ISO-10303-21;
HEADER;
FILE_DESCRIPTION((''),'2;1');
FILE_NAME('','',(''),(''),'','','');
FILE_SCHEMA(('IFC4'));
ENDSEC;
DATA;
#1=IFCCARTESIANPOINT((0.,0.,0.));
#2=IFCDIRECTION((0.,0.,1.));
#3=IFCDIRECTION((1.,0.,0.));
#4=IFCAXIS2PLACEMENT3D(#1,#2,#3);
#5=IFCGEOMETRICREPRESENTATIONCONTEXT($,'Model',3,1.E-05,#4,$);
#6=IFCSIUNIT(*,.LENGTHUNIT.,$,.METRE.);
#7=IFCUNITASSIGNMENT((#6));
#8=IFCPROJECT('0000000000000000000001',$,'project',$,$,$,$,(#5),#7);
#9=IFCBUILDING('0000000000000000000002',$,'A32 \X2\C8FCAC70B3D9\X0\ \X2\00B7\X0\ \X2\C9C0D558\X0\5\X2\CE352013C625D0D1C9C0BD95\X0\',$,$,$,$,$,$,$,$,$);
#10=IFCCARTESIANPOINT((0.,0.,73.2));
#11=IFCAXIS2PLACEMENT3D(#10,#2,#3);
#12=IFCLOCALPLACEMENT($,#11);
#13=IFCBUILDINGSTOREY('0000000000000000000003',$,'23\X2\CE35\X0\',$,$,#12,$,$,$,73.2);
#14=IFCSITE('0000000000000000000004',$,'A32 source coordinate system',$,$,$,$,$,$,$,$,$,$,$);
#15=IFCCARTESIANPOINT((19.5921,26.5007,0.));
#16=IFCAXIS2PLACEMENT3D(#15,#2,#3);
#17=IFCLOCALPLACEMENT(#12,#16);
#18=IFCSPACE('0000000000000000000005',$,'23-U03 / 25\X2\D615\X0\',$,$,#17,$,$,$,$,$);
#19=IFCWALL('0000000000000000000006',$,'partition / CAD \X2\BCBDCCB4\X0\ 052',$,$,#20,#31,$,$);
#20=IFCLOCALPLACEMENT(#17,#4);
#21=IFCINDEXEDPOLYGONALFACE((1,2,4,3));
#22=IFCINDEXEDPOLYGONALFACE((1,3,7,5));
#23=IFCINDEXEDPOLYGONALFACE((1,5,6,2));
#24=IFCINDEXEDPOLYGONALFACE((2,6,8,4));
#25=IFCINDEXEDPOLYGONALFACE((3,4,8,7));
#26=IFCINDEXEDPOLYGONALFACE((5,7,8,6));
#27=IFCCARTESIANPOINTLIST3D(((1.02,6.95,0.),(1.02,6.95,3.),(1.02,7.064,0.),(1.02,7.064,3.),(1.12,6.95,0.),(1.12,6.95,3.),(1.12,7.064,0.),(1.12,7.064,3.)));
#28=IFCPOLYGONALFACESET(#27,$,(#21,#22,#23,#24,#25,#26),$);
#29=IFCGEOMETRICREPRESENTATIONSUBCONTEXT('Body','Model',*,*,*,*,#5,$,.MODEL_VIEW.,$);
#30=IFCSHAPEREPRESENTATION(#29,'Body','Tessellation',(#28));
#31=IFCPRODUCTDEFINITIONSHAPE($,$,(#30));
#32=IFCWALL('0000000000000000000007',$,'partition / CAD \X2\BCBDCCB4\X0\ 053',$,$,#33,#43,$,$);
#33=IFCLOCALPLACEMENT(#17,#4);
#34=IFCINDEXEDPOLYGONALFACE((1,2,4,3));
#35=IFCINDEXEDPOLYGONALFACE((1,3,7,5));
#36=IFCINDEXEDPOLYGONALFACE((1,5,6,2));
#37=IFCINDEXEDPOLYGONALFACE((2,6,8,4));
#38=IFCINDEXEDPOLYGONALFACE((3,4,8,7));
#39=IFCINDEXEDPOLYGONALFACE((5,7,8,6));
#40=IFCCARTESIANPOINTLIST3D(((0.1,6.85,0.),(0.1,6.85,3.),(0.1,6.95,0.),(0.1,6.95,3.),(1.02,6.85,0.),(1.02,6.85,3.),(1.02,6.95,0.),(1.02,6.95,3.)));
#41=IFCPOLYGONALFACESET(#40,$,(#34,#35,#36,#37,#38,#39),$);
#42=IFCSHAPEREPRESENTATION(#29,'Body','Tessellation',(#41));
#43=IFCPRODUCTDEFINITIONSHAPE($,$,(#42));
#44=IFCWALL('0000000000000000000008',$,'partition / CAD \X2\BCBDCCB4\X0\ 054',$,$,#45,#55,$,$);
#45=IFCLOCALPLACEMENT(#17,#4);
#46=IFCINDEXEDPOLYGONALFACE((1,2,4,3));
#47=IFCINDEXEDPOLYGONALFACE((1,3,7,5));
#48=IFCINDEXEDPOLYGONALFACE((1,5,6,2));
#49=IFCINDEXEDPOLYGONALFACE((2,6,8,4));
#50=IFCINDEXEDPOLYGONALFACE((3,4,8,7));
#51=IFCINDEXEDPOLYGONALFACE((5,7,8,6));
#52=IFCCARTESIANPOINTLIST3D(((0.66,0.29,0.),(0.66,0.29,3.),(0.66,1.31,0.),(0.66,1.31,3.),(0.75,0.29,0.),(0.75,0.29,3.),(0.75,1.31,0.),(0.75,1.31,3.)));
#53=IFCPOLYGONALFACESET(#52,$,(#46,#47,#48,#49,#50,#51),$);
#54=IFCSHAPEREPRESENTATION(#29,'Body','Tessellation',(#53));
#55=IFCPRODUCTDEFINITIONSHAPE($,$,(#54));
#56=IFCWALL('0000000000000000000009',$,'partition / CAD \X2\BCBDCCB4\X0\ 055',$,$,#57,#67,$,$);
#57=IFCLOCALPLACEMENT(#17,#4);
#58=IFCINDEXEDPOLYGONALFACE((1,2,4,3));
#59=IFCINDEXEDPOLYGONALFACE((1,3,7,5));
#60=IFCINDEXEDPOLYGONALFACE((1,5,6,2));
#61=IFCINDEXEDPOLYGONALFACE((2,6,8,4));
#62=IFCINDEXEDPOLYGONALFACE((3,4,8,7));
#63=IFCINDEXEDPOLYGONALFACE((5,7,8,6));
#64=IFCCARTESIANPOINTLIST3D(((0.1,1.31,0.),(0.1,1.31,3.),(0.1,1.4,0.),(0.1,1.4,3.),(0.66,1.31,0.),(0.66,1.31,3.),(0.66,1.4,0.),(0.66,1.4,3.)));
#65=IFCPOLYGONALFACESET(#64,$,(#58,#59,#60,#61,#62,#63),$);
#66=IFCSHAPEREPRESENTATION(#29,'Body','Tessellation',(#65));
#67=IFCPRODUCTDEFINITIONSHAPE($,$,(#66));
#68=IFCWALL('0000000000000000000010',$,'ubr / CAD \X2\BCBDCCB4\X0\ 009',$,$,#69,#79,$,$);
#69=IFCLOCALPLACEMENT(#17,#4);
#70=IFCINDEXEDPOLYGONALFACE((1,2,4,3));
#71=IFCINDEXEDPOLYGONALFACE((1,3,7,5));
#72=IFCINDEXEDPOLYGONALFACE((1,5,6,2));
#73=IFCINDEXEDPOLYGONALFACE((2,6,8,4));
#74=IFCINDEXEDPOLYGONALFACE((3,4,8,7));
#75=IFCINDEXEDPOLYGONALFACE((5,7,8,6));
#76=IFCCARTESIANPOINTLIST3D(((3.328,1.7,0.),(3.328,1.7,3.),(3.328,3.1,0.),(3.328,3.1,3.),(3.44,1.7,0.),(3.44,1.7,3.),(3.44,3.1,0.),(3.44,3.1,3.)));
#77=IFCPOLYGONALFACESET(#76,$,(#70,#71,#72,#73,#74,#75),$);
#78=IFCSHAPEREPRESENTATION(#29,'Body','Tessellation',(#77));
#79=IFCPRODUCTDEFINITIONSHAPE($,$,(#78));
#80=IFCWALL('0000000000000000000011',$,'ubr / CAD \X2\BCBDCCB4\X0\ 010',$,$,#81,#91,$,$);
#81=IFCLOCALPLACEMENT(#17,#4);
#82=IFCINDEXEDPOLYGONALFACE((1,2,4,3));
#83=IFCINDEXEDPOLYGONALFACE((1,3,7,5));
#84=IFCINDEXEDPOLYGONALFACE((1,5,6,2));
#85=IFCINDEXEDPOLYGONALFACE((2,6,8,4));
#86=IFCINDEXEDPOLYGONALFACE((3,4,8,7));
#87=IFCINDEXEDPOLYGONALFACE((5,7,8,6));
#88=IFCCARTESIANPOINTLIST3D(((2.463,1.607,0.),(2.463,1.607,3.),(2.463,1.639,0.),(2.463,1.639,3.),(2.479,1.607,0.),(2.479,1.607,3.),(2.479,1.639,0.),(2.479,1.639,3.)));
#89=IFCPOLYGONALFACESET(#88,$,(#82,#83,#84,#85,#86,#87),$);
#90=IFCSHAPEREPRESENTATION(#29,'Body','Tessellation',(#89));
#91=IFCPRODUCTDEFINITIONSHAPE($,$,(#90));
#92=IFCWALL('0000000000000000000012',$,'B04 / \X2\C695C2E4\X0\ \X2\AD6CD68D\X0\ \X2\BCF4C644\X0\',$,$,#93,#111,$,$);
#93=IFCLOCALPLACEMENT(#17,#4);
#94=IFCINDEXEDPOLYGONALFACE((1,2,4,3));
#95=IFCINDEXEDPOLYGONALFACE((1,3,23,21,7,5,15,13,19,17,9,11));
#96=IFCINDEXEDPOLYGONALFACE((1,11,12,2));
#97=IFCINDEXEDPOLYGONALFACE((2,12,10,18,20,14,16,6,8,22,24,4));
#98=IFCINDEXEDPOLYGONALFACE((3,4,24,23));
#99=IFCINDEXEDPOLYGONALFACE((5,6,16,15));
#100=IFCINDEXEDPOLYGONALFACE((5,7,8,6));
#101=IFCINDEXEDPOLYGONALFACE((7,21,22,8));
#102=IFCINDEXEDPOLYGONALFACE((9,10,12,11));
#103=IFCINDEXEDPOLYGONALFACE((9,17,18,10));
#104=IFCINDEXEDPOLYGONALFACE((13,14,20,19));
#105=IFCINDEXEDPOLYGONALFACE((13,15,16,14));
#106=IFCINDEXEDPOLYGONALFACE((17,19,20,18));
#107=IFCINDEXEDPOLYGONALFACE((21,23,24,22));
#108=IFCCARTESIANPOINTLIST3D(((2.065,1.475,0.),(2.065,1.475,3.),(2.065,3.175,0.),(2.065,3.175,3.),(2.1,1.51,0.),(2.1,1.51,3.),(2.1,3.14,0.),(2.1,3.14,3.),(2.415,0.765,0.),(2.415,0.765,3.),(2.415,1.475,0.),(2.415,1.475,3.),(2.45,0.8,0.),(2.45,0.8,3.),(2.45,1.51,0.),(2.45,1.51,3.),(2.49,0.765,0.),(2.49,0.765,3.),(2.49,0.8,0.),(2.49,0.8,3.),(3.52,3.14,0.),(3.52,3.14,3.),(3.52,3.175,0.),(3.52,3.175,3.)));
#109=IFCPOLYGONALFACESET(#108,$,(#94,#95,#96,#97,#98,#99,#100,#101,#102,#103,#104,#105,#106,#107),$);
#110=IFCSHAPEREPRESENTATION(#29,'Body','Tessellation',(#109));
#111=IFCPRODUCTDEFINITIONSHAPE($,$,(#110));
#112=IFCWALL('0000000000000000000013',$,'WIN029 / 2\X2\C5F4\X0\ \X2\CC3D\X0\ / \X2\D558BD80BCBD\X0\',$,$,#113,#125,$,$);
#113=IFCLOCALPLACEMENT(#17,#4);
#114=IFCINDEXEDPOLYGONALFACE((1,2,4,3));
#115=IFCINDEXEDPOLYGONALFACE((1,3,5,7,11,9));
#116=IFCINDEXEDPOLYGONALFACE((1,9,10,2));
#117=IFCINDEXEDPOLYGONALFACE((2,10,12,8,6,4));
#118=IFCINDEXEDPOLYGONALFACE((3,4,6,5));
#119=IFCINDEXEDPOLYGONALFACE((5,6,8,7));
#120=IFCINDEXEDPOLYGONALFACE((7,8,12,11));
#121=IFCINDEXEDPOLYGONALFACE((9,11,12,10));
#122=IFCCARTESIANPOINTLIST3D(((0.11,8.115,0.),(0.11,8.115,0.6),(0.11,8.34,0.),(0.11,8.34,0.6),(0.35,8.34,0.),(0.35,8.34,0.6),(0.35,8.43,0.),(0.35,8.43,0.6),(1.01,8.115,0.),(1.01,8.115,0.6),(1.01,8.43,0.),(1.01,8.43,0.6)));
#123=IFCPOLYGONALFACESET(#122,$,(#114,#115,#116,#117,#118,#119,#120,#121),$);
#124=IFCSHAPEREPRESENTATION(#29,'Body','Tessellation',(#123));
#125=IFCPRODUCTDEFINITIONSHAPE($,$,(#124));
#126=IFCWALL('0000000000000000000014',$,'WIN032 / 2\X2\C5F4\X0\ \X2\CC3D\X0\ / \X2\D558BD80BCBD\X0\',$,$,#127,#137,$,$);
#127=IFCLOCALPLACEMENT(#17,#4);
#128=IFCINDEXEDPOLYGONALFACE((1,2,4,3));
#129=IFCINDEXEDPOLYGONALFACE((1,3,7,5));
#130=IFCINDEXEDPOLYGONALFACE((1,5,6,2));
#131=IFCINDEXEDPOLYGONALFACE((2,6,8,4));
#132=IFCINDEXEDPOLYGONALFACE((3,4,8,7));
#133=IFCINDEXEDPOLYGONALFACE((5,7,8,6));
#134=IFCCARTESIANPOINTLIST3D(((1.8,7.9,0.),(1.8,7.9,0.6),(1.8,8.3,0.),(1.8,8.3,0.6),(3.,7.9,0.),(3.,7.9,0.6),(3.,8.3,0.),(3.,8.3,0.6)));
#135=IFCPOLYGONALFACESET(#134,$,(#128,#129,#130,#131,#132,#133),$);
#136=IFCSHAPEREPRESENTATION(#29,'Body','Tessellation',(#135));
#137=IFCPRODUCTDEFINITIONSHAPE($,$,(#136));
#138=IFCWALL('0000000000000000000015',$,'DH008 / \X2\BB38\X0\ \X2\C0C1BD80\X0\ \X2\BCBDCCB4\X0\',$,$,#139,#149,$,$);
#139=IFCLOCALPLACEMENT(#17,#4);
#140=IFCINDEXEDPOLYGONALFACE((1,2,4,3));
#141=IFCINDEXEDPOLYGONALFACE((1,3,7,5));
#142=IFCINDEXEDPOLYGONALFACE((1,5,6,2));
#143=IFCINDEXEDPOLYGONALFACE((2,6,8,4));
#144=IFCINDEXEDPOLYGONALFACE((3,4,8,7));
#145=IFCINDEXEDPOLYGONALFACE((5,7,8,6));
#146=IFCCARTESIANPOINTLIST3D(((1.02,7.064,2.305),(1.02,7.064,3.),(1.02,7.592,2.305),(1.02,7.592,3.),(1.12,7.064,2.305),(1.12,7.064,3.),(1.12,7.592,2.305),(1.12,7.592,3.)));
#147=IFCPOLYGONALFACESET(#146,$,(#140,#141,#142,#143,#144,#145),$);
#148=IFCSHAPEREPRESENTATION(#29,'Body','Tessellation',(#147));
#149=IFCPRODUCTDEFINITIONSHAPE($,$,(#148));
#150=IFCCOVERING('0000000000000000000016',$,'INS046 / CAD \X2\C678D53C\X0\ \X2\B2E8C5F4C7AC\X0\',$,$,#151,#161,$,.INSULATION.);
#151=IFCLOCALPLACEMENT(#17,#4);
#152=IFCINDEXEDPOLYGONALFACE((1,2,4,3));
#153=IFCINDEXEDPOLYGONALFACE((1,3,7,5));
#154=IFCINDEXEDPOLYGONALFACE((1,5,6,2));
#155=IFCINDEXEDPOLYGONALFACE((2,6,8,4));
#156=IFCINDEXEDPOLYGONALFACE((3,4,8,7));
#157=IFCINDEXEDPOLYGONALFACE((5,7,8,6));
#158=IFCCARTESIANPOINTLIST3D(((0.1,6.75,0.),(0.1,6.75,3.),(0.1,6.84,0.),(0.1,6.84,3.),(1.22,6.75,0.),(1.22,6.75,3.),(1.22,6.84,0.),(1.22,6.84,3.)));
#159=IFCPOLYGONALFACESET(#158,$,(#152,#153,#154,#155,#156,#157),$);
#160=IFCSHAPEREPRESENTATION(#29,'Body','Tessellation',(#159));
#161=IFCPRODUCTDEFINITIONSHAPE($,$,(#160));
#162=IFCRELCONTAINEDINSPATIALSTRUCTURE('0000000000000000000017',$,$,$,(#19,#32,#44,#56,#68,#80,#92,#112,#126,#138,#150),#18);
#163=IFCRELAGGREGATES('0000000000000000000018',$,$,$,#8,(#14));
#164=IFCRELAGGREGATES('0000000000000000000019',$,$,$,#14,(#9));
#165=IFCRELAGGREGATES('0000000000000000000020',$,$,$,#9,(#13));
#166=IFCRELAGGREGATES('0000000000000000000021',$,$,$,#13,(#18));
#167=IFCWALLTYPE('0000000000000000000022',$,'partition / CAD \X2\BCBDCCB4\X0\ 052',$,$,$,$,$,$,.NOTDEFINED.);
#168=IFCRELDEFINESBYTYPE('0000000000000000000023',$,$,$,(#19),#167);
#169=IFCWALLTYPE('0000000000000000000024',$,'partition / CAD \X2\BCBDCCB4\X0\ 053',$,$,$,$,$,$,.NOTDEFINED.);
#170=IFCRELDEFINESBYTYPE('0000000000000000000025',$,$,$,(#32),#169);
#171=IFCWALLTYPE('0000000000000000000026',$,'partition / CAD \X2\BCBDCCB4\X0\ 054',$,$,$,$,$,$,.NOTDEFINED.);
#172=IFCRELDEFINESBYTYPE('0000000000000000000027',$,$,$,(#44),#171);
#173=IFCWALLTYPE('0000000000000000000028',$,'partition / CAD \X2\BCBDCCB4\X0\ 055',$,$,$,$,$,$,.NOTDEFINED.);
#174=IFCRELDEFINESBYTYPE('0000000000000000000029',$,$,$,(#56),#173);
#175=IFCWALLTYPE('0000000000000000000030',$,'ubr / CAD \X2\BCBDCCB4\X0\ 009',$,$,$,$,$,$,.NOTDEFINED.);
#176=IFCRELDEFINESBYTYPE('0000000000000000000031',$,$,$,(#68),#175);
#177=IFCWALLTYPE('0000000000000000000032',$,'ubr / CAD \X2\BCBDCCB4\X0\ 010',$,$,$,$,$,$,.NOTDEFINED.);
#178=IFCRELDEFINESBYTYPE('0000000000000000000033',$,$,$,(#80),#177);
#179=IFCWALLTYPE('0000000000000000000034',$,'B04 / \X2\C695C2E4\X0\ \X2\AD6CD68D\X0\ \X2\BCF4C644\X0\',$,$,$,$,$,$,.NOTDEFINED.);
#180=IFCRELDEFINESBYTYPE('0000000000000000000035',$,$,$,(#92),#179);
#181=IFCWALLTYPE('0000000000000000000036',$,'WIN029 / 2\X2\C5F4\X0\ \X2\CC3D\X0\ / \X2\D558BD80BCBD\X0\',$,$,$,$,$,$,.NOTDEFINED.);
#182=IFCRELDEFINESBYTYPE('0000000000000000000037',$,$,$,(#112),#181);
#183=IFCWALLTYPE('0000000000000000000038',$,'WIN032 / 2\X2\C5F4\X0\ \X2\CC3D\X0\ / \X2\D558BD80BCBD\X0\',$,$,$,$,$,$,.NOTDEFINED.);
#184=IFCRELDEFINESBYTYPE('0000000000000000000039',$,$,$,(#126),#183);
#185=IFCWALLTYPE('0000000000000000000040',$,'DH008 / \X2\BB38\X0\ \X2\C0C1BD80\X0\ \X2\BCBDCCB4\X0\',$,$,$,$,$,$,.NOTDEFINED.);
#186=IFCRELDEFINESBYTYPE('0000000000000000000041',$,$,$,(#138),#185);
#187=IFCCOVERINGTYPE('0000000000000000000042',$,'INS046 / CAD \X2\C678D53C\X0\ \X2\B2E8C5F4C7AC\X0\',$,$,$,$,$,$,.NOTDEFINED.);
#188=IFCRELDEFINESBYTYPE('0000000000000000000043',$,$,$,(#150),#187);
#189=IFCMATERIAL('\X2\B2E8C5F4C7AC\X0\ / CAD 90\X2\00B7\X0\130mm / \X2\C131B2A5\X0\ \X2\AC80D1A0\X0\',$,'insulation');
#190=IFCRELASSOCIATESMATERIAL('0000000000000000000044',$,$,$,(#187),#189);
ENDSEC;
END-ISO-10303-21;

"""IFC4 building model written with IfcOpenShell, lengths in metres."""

from ifc_helpers import new_model, si_unit, frame, origin, origin_with_axes, place, context, subcontext, project, spatial, polyline, outline, extrude, source, transform, mapped, material, type_object, type_shapes, element, save


model = new_model("IFC4")

# Units and contexts
model_context = context("Model", 3, precision=1e-05, world=origin_with_axes())
body_context = subcontext(model_context, "Body", "Model", "MODEL_VIEW")
ifc_project = project(units=[si_unit("LENGTHUNIT", "METRE")], contexts=[model_context])

# Site, building, storey, space
storey_placement = place(None, frame((0.0, 0.0, 73.2), z_axis=(0.0, 0.0, 1.0), x_axis=(1.0, 0.0, 0.0)))
space_placement = place(storey_placement, frame((19.5921, 26.5007, 0.0), z_axis=(0.0, 0.0, 1.0), x_axis=(1.0, 0.0, 0.0)))
site = spatial("IfcSite", under=ifc_project, Name="A32 source coordinate system")
building = spatial("IfcBuilding", under=site, Name="A32 주거동 · 지하5층–옥탑지붕")
storey = spatial("IfcBuildingStorey", under=building, at=storey_placement, Name="23층", Elevation=73.2)
space = spatial("IfcSpace", under=storey, at=space_placement, Name="23-U03 / 25형")

# Walls
wall_type_1 = type_object("IfcWallType", Name="partition / CAD 벽체 052", PredefinedType="NOTDEFINED")
shared_shape_1 = source(origin(), body_context, "Body", "SweptSolid", [
    extrude(outline(polyline([(1.12, 6.95), (1.02, 6.95), (1.02, 7.064), (1.12, 7.064), (1.12, 6.95)])), origin(), (0.0, 0.0, 1.0), 3.0),
])
type_shapes(wall_type_1, [shared_shape_1])
wall_1_placement = place(space_placement, origin_with_axes())
element("IfcWall", 1, at=wall_1_placement, inside=space, type_object=wall_type_1, Name="partition / CAD 벽체 052", context=body_context, shape_type="MappedRepresentation", body=[
    mapped(shared_shape_1, transform((0.0, 0.0, 0.0), scale=1.0)),
])
wall_type_2 = type_object("IfcWallType", Name="partition / CAD 벽체 053", PredefinedType="NOTDEFINED")
shared_shape_2 = source(origin(), body_context, "Body", "SweptSolid", [
    extrude(outline(polyline([(1.02, 6.95), (1.02, 6.85), (0.1, 6.85), (0.1, 6.95), (1.02, 6.95)])), origin(), (0.0, 0.0, 1.0), 3.0),
])
type_shapes(wall_type_2, [shared_shape_2])
wall_2_placement = place(space_placement, origin_with_axes())
element("IfcWall", 2, at=wall_2_placement, inside=space, type_object=wall_type_2, Name="partition / CAD 벽체 053", context=body_context, shape_type="MappedRepresentation", body=[
    mapped(shared_shape_2, transform((0.0, 0.0, 0.0), scale=1.0)),
])
wall_type_3 = type_object("IfcWallType", Name="partition / CAD 벽체 054", PredefinedType="NOTDEFINED")
shared_shape_3 = source(origin(), body_context, "Body", "SweptSolid", [
    extrude(outline(polyline([(0.75, 0.29), (0.66, 0.29), (0.66, 1.31), (0.75, 1.31), (0.75, 0.29)])), origin(), (0.0, 0.0, 1.0), 3.0),
])
type_shapes(wall_type_3, [shared_shape_3])
wall_3_placement = place(space_placement, origin_with_axes())
element("IfcWall", 3, at=wall_3_placement, inside=space, type_object=wall_type_3, Name="partition / CAD 벽체 054", context=body_context, shape_type="MappedRepresentation", body=[
    mapped(shared_shape_3, transform((0.0, 0.0, 0.0), scale=1.0)),
])
wall_type_4 = type_object("IfcWallType", Name="partition / CAD 벽체 055", PredefinedType="NOTDEFINED")
shared_shape_4 = source(origin(), body_context, "Body", "SweptSolid", [
    extrude(outline(polyline([(0.66, 1.4), (0.66, 1.31), (0.1, 1.31), (0.1, 1.4), (0.66, 1.4)])), origin(), (0.0, 0.0, 1.0), 3.0),
])
type_shapes(wall_type_4, [shared_shape_4])
wall_4_placement = place(space_placement, origin_with_axes())
element("IfcWall", 4, at=wall_4_placement, inside=space, type_object=wall_type_4, Name="partition / CAD 벽체 055", context=body_context, shape_type="MappedRepresentation", body=[
    mapped(shared_shape_4, transform((0.0, 0.0, 0.0), scale=1.0)),
])
wall_type_5 = type_object("IfcWallType", Name="ubr / CAD 벽체 009", PredefinedType="NOTDEFINED")
shared_shape_5 = source(origin(), body_context, "Body", "SweptSolid", [
    extrude(outline(polyline([(3.328, 3.1), (3.44, 3.1), (3.44, 1.7), (3.328, 1.7), (3.328, 3.1)])), origin(), (0.0, 0.0, 1.0), 3.0),
])
type_shapes(wall_type_5, [shared_shape_5])
wall_5_placement = place(space_placement, origin_with_axes())
element("IfcWall", 5, at=wall_5_placement, inside=space, type_object=wall_type_5, Name="ubr / CAD 벽체 009", context=body_context, shape_type="MappedRepresentation", body=[
    mapped(shared_shape_5, transform((0.0, 0.0, 0.0), scale=1.0)),
])
wall_type_6 = type_object("IfcWallType", Name="ubr / CAD 벽체 010", PredefinedType="NOTDEFINED")
shared_shape_6 = source(origin(), body_context, "Body", "SweptSolid", [
    extrude(outline(polyline([(2.463, 1.607), (2.463, 1.639), (2.479, 1.639), (2.479, 1.607), (2.463, 1.607)])), origin(), (0.0, 0.0, 1.0), 3.0),
])
type_shapes(wall_type_6, [shared_shape_6])
wall_6_placement = place(space_placement, origin_with_axes())
element("IfcWall", 6, at=wall_6_placement, inside=space, type_object=wall_type_6, Name="ubr / CAD 벽체 010", context=body_context, shape_type="MappedRepresentation", body=[
    mapped(shared_shape_6, transform((0.0, 0.0, 0.0), scale=1.0)),
])
wall_type_7 = type_object("IfcWallType", Name="B04 / 욕실 구획 보완", PredefinedType="NOTDEFINED")
shared_shape_7 = source(origin(), body_context, "Body", "SweptSolid", [
    extrude(outline(polyline([(3.52, 3.175), (3.52, 3.14), (2.1, 3.14), (2.1, 1.51), (2.45, 1.51), (2.45, 0.8), (2.49, 0.8), (2.49, 0.765), (2.415, 0.765), (2.415, 1.475), (2.065, 1.475), (2.065, 3.175), (3.52, 3.175)])), origin(), (0.0, 0.0, 1.0), 3.0),
])
type_shapes(wall_type_7, [shared_shape_7])
wall_7_placement = place(space_placement, origin_with_axes())
element("IfcWall", 7, at=wall_7_placement, inside=space, type_object=wall_type_7, Name="B04 / 욕실 구획 보완", context=body_context, shape_type="MappedRepresentation", body=[
    mapped(shared_shape_7, transform((0.0, 0.0, 0.0), scale=1.0)),
])
wall_type_8 = type_object("IfcWallType", Name="WIN029 / 2열 창 / 하부벽", PredefinedType="NOTDEFINED")
shared_shape_8 = source(origin(), body_context, "Body", "SweptSolid", [
    extrude(outline(polyline([(1.01, 8.115), (0.11, 8.115), (0.11, 8.34), (0.35, 8.34), (0.35, 8.43), (1.01, 8.43), (1.01, 8.115)])), origin(), (0.0, 0.0, 1.0), 0.6),
])
type_shapes(wall_type_8, [shared_shape_8])
wall_8_placement = place(space_placement, origin_with_axes())
element("IfcWall", 8, at=wall_8_placement, inside=space, type_object=wall_type_8, Name="WIN029 / 2열 창 / 하부벽", context=body_context, shape_type="MappedRepresentation", body=[
    mapped(shared_shape_8, transform((0.0, 0.0, 0.0), scale=1.0)),
])
wall_type_9 = type_object("IfcWallType", Name="WIN032 / 2열 창 / 하부벽", PredefinedType="NOTDEFINED")
shared_shape_9 = source(origin(), body_context, "Body", "SweptSolid", [
    extrude(outline(polyline([(3.0, 7.9), (1.8, 7.9), (1.8, 8.3), (3.0, 8.3), (3.0, 7.9)])), origin(), (0.0, 0.0, 1.0), 0.6),
])
type_shapes(wall_type_9, [shared_shape_9])
wall_9_placement = place(space_placement, origin_with_axes())
element("IfcWall", 9, at=wall_9_placement, inside=space, type_object=wall_type_9, Name="WIN032 / 2열 창 / 하부벽", context=body_context, shape_type="MappedRepresentation", body=[
    mapped(shared_shape_9, transform((0.0, 0.0, 0.0), scale=1.0)),
])
wall_type_10 = type_object("IfcWallType", Name="DH008 / 문 상부 벽체", PredefinedType="NOTDEFINED")
shared_shape_10 = source(origin(), body_context, "Body", "SweptSolid", [
    extrude(outline(polyline([(1.12, 7.064), (1.02, 7.064), (1.02, 7.592), (1.12, 7.592), (1.12, 7.064)])), frame((0.0, 0.0, 2.305)), (0.0, 0.0, 1.0), 0.695),
])
type_shapes(wall_type_10, [shared_shape_10])
wall_10_placement = place(space_placement, origin_with_axes())
element("IfcWall", 10, at=wall_10_placement, inside=space, type_object=wall_type_10, Name="DH008 / 문 상부 벽체", context=body_context, shape_type="MappedRepresentation", body=[
    mapped(shared_shape_10, transform((0.0, 0.0, 0.0), scale=1.0)),
])

# Covering
ifc_material = material(Name="단열재 / CAD 90·130mm / 성능 검토", Category="insulation")
covering_type_1 = type_object("IfcCoveringType", Name="INS046 / CAD 외피 단열재", PredefinedType="NOTDEFINED", material=ifc_material)
shared_shape_11 = source(origin(), body_context, "Body", "SweptSolid", [
    extrude(outline(polyline([(0.1, 6.84), (1.22, 6.84), (1.22, 6.75), (0.1, 6.75), (0.1, 6.84)])), origin(), (0.0, 0.0, 1.0), 3.0),
])
type_shapes(covering_type_1, [shared_shape_11])
covering_1_placement = place(space_placement, origin_with_axes())
element("IfcCovering", 11, at=covering_1_placement, inside=space, type_object=covering_type_1, Name="INS046 / CAD 외피 단열재", PredefinedType="INSULATION", context=body_context, shape_type="MappedRepresentation", body=[
    mapped(shared_shape_11, transform((0.0, 0.0, 0.0), scale=1.0)),
])

save(model, "model.ifc")
